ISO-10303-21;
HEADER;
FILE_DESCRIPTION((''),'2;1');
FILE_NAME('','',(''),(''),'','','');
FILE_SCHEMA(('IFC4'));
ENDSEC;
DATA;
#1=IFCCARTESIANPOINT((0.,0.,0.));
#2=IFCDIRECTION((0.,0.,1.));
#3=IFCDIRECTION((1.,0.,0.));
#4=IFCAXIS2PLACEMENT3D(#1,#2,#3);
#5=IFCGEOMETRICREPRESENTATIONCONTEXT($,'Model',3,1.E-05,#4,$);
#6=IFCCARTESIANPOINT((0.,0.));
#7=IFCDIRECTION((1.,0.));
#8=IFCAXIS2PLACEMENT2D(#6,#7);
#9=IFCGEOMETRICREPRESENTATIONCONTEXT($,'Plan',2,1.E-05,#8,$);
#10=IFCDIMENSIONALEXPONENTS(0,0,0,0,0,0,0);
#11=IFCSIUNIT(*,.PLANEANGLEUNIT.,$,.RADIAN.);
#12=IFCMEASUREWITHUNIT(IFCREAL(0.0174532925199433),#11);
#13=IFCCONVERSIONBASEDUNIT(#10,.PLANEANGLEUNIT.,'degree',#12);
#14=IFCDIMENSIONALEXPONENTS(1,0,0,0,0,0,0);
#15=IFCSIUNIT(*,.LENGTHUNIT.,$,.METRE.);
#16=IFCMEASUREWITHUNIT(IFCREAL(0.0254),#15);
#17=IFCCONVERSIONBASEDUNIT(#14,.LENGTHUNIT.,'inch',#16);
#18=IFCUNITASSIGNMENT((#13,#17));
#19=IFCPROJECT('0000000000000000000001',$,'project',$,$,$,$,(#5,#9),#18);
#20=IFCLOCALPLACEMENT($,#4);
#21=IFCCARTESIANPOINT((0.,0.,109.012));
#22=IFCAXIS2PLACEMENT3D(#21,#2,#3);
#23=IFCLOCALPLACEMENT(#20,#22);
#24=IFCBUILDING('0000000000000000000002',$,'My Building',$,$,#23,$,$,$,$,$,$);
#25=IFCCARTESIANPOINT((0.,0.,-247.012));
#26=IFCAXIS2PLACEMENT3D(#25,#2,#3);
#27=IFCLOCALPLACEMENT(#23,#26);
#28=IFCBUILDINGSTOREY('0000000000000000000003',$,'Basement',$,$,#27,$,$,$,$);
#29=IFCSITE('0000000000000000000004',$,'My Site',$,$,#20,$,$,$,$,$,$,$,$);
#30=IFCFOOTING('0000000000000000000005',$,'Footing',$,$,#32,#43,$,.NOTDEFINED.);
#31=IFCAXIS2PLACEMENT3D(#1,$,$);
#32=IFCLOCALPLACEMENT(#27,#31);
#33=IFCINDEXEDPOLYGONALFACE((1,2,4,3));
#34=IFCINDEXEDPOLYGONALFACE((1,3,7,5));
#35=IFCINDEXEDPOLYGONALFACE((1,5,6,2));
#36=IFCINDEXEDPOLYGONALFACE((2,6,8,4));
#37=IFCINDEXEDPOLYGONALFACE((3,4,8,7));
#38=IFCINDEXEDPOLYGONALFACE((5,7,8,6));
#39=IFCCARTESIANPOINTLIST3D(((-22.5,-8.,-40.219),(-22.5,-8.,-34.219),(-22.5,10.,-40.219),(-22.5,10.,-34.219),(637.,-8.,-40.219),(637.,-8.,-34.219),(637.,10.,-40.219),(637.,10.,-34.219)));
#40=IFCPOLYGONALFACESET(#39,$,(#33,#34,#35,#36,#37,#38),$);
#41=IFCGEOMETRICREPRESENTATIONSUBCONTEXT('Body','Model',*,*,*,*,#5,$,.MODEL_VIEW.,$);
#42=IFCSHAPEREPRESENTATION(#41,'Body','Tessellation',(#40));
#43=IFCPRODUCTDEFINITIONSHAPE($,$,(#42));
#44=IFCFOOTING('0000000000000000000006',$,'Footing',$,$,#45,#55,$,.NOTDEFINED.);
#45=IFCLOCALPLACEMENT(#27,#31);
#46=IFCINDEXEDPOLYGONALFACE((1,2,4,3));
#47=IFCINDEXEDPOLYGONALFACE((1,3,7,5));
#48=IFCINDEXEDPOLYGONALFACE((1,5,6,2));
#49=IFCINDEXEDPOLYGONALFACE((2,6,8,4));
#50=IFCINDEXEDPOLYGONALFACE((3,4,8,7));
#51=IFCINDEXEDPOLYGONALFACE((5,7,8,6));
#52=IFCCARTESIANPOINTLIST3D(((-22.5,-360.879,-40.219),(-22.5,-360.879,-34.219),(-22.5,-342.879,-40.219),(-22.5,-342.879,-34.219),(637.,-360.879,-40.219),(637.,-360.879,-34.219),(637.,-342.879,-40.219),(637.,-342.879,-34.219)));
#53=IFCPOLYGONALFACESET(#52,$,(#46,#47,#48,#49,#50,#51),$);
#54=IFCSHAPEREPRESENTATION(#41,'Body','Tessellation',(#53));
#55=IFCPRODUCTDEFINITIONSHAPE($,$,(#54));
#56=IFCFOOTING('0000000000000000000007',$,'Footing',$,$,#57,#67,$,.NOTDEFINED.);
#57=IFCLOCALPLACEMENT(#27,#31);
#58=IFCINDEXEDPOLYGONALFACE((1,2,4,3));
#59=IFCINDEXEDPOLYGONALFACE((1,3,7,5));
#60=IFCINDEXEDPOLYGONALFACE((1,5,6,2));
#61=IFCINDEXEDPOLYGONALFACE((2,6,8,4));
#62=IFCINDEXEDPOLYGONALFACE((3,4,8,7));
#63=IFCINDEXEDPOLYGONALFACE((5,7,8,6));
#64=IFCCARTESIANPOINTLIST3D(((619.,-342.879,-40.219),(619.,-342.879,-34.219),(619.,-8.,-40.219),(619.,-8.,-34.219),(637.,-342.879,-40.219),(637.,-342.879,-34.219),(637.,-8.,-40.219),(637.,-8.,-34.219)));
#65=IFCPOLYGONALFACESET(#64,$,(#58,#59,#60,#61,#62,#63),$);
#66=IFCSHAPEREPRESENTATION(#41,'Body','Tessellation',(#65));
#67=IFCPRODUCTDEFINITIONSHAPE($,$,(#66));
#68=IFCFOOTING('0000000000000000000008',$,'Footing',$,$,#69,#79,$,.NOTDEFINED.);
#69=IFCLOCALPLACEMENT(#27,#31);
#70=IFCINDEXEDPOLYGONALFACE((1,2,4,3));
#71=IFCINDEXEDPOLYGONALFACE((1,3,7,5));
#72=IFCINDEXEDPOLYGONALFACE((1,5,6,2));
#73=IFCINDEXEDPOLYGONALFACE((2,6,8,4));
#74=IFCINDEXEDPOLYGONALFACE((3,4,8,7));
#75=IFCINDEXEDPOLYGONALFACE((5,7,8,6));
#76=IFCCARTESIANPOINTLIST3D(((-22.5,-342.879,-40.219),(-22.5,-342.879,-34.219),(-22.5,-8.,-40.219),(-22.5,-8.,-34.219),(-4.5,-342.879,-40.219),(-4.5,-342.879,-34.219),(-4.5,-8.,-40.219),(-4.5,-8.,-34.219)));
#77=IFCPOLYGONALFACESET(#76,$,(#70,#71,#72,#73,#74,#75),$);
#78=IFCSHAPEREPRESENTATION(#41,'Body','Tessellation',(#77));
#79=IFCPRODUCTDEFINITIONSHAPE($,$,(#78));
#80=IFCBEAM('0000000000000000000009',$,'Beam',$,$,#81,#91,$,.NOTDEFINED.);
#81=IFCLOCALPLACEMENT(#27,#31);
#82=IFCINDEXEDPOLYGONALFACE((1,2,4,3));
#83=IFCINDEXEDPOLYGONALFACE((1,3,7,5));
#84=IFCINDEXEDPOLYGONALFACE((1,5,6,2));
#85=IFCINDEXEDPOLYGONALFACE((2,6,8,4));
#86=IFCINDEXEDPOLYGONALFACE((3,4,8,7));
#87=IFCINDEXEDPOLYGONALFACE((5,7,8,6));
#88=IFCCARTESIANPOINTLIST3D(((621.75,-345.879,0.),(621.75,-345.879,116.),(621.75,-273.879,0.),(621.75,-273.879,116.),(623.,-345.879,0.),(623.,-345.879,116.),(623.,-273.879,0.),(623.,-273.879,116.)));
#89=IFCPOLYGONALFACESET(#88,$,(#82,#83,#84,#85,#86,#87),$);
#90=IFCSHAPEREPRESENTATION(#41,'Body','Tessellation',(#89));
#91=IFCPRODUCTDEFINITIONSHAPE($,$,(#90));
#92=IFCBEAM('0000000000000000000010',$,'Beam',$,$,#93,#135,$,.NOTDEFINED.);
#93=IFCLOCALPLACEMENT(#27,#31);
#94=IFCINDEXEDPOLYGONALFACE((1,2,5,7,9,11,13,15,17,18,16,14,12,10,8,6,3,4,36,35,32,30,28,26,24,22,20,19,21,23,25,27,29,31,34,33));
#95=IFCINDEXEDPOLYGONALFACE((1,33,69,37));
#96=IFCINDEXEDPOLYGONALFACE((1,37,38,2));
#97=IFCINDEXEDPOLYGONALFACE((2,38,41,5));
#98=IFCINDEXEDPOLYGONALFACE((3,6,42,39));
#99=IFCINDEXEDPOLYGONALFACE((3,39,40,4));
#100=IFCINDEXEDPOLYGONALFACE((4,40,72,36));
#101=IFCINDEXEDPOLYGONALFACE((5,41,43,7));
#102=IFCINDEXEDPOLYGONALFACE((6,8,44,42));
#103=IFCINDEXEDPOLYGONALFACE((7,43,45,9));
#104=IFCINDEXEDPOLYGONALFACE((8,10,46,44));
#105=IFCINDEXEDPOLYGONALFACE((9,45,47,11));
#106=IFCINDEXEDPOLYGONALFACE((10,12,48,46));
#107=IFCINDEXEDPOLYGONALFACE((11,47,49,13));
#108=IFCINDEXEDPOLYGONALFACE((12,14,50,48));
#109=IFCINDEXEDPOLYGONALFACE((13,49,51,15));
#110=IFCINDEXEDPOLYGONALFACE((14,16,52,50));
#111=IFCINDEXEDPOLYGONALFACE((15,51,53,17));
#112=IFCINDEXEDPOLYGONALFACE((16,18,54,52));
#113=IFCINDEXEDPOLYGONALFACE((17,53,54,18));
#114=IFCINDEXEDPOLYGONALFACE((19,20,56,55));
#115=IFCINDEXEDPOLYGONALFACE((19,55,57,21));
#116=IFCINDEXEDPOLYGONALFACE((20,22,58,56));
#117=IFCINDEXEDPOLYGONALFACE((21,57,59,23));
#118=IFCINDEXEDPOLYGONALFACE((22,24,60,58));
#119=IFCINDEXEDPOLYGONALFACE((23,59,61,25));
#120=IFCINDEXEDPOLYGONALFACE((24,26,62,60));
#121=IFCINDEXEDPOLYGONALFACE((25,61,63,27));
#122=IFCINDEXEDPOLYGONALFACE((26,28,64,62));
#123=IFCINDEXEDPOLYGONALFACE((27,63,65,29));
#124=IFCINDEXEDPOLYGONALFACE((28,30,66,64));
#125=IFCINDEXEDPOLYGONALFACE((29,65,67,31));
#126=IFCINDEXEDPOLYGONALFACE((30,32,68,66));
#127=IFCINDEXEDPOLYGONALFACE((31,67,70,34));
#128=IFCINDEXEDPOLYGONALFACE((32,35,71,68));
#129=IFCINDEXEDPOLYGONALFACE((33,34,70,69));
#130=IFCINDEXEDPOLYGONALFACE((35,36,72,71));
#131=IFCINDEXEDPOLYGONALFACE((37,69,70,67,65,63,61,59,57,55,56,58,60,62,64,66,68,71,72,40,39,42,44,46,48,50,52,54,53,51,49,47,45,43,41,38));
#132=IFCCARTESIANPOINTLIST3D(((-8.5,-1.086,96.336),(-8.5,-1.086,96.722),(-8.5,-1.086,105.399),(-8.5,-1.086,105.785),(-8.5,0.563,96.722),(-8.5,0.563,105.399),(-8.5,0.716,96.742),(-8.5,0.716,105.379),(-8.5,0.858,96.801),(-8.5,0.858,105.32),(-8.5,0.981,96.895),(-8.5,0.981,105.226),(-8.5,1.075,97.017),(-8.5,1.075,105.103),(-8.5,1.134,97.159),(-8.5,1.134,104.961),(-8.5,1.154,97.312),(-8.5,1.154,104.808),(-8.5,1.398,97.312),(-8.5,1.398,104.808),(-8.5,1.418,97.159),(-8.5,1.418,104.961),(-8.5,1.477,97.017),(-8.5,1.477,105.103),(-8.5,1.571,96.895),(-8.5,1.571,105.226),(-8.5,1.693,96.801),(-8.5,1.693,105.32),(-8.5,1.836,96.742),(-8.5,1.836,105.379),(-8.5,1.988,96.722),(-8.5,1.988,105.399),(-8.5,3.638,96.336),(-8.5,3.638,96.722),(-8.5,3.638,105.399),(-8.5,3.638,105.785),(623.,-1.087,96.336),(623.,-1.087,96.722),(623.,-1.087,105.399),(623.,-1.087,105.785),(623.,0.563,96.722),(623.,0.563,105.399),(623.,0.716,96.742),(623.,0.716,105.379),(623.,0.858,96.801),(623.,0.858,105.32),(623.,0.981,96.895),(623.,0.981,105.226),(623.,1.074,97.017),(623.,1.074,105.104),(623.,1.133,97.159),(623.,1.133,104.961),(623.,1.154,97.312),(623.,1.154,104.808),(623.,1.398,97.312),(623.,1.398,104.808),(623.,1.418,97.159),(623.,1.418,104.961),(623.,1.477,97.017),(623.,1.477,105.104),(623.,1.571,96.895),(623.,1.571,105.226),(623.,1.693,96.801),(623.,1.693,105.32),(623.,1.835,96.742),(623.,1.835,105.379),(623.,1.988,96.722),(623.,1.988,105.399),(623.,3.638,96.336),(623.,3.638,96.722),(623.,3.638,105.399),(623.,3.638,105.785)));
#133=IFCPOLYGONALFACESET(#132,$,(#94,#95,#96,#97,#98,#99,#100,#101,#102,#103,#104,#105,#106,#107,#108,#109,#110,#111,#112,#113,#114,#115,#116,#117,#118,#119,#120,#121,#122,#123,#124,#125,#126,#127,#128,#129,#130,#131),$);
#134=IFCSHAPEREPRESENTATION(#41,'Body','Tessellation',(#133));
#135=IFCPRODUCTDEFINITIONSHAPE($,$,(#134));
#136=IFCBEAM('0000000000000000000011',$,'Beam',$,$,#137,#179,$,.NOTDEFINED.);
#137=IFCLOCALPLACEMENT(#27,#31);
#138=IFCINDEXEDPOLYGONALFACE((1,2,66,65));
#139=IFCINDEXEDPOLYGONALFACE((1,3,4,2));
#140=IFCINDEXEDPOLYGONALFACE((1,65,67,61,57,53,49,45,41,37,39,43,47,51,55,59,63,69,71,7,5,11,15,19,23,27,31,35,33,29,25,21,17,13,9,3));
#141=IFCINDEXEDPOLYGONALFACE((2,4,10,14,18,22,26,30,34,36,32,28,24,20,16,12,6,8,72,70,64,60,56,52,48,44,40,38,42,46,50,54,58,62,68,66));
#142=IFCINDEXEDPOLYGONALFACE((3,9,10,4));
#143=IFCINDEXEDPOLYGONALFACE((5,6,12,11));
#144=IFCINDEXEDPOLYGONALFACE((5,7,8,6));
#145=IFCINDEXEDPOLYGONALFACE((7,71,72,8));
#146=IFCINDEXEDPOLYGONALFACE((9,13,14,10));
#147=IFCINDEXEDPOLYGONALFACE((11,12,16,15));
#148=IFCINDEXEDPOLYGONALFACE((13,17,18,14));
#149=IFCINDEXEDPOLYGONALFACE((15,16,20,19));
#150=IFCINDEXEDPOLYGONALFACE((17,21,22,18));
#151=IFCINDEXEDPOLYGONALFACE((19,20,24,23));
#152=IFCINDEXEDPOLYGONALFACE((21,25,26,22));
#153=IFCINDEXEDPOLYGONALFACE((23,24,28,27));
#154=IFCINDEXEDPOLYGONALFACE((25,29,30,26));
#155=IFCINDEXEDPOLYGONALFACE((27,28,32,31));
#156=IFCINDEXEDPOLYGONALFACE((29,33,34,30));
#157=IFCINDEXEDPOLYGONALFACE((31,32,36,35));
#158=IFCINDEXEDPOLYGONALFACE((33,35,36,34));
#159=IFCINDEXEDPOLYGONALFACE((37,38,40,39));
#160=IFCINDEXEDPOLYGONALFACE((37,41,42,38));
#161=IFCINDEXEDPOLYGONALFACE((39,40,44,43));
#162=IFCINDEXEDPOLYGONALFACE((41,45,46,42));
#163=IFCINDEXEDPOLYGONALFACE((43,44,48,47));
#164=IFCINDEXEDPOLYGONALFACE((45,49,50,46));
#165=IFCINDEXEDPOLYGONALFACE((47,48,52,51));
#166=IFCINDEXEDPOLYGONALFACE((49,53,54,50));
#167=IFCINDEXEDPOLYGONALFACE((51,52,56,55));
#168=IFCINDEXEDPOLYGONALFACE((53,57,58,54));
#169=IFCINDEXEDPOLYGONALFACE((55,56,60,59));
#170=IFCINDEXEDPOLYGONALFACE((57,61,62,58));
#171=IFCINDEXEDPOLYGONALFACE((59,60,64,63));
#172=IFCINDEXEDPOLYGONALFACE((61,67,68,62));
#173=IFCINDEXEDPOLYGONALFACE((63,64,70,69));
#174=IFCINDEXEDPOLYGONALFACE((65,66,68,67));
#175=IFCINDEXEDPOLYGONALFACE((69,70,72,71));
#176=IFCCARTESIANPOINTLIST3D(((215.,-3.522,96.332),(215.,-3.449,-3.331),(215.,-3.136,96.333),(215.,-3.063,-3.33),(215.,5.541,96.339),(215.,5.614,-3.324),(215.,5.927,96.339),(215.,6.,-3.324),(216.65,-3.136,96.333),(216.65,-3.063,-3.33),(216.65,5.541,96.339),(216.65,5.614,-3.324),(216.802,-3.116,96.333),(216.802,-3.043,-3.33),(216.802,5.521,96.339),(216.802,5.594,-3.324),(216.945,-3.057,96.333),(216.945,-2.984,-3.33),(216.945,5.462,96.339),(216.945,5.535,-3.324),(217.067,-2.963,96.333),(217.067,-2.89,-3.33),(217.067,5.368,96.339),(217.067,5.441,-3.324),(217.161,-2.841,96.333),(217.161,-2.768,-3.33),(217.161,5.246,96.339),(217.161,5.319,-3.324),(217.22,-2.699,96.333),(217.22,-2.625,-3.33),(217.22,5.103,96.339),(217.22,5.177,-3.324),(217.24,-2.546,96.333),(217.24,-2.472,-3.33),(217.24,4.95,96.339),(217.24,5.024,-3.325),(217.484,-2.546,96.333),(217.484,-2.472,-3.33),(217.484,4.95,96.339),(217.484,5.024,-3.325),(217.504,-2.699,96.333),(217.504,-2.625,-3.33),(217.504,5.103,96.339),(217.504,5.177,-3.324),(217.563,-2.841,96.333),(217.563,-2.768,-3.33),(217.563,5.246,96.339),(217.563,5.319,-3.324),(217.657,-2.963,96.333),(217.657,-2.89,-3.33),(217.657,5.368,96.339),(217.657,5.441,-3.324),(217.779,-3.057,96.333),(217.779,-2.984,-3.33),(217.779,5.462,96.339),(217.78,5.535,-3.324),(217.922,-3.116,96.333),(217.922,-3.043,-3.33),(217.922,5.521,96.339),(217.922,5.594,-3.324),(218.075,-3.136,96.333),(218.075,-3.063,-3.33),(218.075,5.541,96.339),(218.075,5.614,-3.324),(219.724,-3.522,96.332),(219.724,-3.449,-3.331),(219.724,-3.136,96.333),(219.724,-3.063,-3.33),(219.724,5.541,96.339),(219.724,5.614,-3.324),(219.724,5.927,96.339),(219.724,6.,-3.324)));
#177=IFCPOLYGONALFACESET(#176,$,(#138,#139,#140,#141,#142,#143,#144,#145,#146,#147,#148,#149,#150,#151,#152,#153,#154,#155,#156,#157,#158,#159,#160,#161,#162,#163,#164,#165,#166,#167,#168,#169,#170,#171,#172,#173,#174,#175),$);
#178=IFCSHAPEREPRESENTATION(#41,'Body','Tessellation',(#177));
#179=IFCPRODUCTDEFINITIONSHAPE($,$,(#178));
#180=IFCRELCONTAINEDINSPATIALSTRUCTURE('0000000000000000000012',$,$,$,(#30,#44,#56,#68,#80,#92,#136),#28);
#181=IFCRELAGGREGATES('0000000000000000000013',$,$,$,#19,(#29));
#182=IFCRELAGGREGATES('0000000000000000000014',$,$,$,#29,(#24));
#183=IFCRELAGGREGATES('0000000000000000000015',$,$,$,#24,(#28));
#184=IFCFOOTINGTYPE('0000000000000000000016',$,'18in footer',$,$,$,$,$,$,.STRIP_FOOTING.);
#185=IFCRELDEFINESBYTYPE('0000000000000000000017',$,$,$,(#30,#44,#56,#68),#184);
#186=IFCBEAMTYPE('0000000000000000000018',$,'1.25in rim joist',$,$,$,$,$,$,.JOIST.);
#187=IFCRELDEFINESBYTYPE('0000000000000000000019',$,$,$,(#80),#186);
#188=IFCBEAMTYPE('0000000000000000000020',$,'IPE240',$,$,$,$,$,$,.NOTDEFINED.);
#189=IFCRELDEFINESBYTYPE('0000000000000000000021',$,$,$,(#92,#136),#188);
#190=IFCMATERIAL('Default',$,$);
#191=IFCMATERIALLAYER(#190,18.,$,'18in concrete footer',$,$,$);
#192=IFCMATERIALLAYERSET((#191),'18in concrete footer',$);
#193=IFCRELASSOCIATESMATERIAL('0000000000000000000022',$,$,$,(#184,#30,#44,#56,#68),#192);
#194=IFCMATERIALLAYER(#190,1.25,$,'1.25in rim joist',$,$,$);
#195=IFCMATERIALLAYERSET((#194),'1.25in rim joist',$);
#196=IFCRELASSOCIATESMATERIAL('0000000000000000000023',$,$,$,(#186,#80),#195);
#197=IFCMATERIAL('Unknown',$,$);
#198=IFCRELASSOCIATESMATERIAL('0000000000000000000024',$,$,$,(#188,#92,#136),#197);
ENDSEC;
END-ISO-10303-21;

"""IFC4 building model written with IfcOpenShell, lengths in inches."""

from ifc_helpers import new_model, entity, si_unit, converted_unit, frame, origin_with_axes, origin_2d_with_axis, place, context, subcontext, project, spatial, indexed_curve, i_section, outline, extrude, material, layer, layer_set, layer_usage, material_profile, profile_set, profile_usage, type_object, element, save


model = new_model("IFC4")

# Units and contexts
model_context = context("Model", 3, precision=1e-05, world=origin_with_axes())
plan_context = context("Plan", 2, precision=1e-05, world=origin_2d_with_axis())
body_context = subcontext(model_context, "Body", "Model", "MODEL_VIEW")
ifc_project = project(units=[converted_unit("PLANEANGLEUNIT", "degree", entity("IfcReal", 0.0174532925199433), si_unit("PLANEANGLEUNIT", "RADIAN"), dimensions=[0, 0, 0, 0, 0, 0, 0]), converted_unit("LENGTHUNIT", "inch", entity("IfcReal", 0.0254), si_unit("LENGTHUNIT", "METRE"), dimensions=[1, 0, 0, 0, 0, 0, 0])], contexts=[model_context, plan_context])

# Site, building, storey
site_placement = place(None, origin_with_axes())
site = spatial("IfcSite", under=ifc_project, at=site_placement, Name="My Site")
building_placement = place(site_placement, frame((0.0, 0.0, 109.012), z_axis=(0.0, 0.0, 1.0), x_axis=(1.0, 0.0, 0.0)))
building = spatial("IfcBuilding", under=site, at=building_placement, Name="My Building")
storey_placement = place(building_placement, frame((0.0, 0.0, -247.012), z_axis=(0.0, 0.0, 1.0), x_axis=(1.0, 0.0, 0.0)))
storey = spatial("IfcBuildingStorey", under=building, at=storey_placement, Name="Basement")

# Footings
ifc_material_1 = material(Name="Default")
ifc_layer_1 = layer(ifc_material_1, 18.0, Name="18in concrete footer")
ifc_layer_set_1 = layer_set([ifc_layer_1], Name="18in concrete footer")
ifc_layer_usage_1 = layer_usage(ifc_layer_set_1, "AXIS2", "POSITIVE", 0.0)
footing_type = type_object("IfcFootingType", Name="18in footer", PredefinedType="STRIP_FOOTING", material=ifc_layer_set_1)
footing_1_placement = place(storey_placement, frame((637.0, 10.0, -40.219), z_axis=(0.0, 0.0, 1.0), x_axis=(-1.0, 0.000001, 0.0)))
element("IfcFooting", 1, at=footing_1_placement, inside=storey, type_object=footing_type, material=ifc_layer_usage_1, Name="Footing", PredefinedType="NOTDEFINED", context=body_context, shape_type="SweptSolid", body=[
    extrude(outline(indexed_curve([(0.0, 0.0), (0.0, 18.0), (659.5, 18.0), (659.5, 0.0), (0.0, 0.0)], self_intersect=False)), origin_with_axes(), (0.0, 0.0, 1.0), 6.0),
])
ifc_layer_usage_2 = layer_usage(ifc_layer_set_1, "AXIS2", "POSITIVE", 0.0)
footing_2_placement = place(storey_placement, frame((637.0, -342.879, -40.219), z_axis=(0.0, 0.0, 1.0), x_axis=(-1.0, 0.000001, 0.0)))
element("IfcFooting", 2, at=footing_2_placement, inside=storey, type_object=footing_type, material=ifc_layer_usage_2, Name="Footing", PredefinedType="NOTDEFINED", context=body_context, shape_type="SweptSolid", body=[
    extrude(outline(indexed_curve([(0.0, 0.0), (0.0, 18.0), (659.5, 18.0), (659.5, 0.0), (0.0, 0.0)], self_intersect=False)), origin_with_axes(), (0.0, 0.0, 1.0), 6.0),
])
ifc_layer_usage_3 = layer_usage(ifc_layer_set_1, "AXIS2", "POSITIVE", 0.0)
footing_3_placement = place(storey_placement, frame((637.0, -342.879, -40.219), z_axis=(0.0, 0.0, 1.0), x_axis=(0.000001, 1.0, 0.0)))
element("IfcFooting", 3, at=footing_3_placement, inside=storey, type_object=footing_type, material=ifc_layer_usage_3, Name="Footing", PredefinedType="NOTDEFINED", context=body_context, shape_type="SweptSolid", body=[
    extrude(outline(indexed_curve([(0.0, 0.0), (0.0, 18.0), (334.879, 18.0), (334.879, 0.0), (0.0, 0.0)], self_intersect=False)), origin_with_axes(), (0.0, 0.0, 1.0), 6.0),
])
ifc_layer_usage_4 = layer_usage(ifc_layer_set_1, "AXIS2", "POSITIVE", 0.0)
footing_4_placement = place(storey_placement, frame((-4.5, -342.879, -40.219), z_axis=(0.0, 0.0, 1.0), x_axis=(0.000001, 1.0, 0.0)))
element("IfcFooting", 4, at=footing_4_placement, inside=storey, type_object=footing_type, material=ifc_layer_usage_4, Name="Footing", PredefinedType="NOTDEFINED", context=body_context, shape_type="SweptSolid", body=[
    extrude(outline(indexed_curve([(0.0, 0.0), (0.0, 18.0), (334.879, 18.0), (334.879, 0.0), (0.0, 0.0)], self_intersect=False)), origin_with_axes(), (0.0, 0.0, 1.0), 6.0),
])

# Beams
ifc_layer_2 = layer(ifc_material_1, 1.25, Name="1.25in rim joist")
ifc_layer_set_2 = layer_set([ifc_layer_2], Name="1.25in rim joist")
ifc_layer_usage_5 = layer_usage(ifc_layer_set_2, "AXIS2", "POSITIVE", 0.0)
beam_type_1 = type_object("IfcBeamType", Name="1.25in rim joist", PredefinedType="JOIST", material=ifc_layer_set_2)
beam_1_placement = place(storey_placement, frame((623.0, -345.879, 0.0), z_axis=(0.0, 0.0, 1.0), x_axis=(0.000001, 1.0, 0.0)))
element("IfcBeam", 5, at=beam_1_placement, inside=storey, type_object=beam_type_1, material=ifc_layer_usage_5, Name="Beam", PredefinedType="NOTDEFINED", context=body_context, shape_type="SweptSolid", body=[
    extrude(outline(indexed_curve([(0.0, 0.0), (0.0, 1.25), (72.0, 1.25), (72.0, 0.0), (0.0, 0.0)], self_intersect=False)), origin_with_axes(), (0.0, 0.0, 1.0), 116.0),
])
ifc_material_2 = material(Name="Unknown")
ifc_material_profile = material_profile(ifc_material_2, i_section(OverallWidth=4.724, OverallDepth=9.449, WebThickness=0.244, FlangeThickness=0.386, FilletRadius=0.591))
ifc_profile_set = profile_set([ifc_material_profile])
ifc_profile_usage_1 = profile_usage(ifc_profile_set, cardinal=11)
beam_type_2 = type_object("IfcBeamType", Name="IPE240", PredefinedType="NOTDEFINED", material=ifc_profile_set)
beam_2_placement = place(storey_placement, frame((623.0, 1.276, 101.06), z_axis=(-1.0, 0.0, 0.0), x_axis=(0.0, -1.0, 0.0)))
element("IfcBeam", 6, at=beam_2_placement, inside=storey, type_object=beam_type_2, material=ifc_profile_usage_1, Name="Beam", PredefinedType="NOTDEFINED", context=body_context, shape_type="SweptSolid", body=[
    extrude(i_section(OverallWidth=4.724, OverallDepth=9.449, WebThickness=0.244, FlangeThickness=0.386, FilletRadius=0.591), origin_with_axes(), (0.0, 0.0, 1.0), 631.5),
])
ifc_profile_usage_2 = profile_usage(ifc_profile_set, cardinal=11)
beam_3_placement = place(storey_placement, frame((217.362, 1.276, -3.327), z_axis=(0.0, -0.000737, 1.0), x_axis=(1.0, -0.000003, 0.0)))
element("IfcBeam", 7, at=beam_3_placement, inside=storey, type_object=beam_type_2, material=ifc_profile_usage_2, Name="Beam", PredefinedType="NOTDEFINED", context=body_context, shape_type="SweptSolid", body=[
    extrude(i_section(OverallWidth=4.724, OverallDepth=9.449, WebThickness=0.244, FlangeThickness=0.386, FilletRadius=0.591), origin_with_axes(), (0.0, 0.0, 1.0), 99.663),
])

save(model, "model.ifc")
